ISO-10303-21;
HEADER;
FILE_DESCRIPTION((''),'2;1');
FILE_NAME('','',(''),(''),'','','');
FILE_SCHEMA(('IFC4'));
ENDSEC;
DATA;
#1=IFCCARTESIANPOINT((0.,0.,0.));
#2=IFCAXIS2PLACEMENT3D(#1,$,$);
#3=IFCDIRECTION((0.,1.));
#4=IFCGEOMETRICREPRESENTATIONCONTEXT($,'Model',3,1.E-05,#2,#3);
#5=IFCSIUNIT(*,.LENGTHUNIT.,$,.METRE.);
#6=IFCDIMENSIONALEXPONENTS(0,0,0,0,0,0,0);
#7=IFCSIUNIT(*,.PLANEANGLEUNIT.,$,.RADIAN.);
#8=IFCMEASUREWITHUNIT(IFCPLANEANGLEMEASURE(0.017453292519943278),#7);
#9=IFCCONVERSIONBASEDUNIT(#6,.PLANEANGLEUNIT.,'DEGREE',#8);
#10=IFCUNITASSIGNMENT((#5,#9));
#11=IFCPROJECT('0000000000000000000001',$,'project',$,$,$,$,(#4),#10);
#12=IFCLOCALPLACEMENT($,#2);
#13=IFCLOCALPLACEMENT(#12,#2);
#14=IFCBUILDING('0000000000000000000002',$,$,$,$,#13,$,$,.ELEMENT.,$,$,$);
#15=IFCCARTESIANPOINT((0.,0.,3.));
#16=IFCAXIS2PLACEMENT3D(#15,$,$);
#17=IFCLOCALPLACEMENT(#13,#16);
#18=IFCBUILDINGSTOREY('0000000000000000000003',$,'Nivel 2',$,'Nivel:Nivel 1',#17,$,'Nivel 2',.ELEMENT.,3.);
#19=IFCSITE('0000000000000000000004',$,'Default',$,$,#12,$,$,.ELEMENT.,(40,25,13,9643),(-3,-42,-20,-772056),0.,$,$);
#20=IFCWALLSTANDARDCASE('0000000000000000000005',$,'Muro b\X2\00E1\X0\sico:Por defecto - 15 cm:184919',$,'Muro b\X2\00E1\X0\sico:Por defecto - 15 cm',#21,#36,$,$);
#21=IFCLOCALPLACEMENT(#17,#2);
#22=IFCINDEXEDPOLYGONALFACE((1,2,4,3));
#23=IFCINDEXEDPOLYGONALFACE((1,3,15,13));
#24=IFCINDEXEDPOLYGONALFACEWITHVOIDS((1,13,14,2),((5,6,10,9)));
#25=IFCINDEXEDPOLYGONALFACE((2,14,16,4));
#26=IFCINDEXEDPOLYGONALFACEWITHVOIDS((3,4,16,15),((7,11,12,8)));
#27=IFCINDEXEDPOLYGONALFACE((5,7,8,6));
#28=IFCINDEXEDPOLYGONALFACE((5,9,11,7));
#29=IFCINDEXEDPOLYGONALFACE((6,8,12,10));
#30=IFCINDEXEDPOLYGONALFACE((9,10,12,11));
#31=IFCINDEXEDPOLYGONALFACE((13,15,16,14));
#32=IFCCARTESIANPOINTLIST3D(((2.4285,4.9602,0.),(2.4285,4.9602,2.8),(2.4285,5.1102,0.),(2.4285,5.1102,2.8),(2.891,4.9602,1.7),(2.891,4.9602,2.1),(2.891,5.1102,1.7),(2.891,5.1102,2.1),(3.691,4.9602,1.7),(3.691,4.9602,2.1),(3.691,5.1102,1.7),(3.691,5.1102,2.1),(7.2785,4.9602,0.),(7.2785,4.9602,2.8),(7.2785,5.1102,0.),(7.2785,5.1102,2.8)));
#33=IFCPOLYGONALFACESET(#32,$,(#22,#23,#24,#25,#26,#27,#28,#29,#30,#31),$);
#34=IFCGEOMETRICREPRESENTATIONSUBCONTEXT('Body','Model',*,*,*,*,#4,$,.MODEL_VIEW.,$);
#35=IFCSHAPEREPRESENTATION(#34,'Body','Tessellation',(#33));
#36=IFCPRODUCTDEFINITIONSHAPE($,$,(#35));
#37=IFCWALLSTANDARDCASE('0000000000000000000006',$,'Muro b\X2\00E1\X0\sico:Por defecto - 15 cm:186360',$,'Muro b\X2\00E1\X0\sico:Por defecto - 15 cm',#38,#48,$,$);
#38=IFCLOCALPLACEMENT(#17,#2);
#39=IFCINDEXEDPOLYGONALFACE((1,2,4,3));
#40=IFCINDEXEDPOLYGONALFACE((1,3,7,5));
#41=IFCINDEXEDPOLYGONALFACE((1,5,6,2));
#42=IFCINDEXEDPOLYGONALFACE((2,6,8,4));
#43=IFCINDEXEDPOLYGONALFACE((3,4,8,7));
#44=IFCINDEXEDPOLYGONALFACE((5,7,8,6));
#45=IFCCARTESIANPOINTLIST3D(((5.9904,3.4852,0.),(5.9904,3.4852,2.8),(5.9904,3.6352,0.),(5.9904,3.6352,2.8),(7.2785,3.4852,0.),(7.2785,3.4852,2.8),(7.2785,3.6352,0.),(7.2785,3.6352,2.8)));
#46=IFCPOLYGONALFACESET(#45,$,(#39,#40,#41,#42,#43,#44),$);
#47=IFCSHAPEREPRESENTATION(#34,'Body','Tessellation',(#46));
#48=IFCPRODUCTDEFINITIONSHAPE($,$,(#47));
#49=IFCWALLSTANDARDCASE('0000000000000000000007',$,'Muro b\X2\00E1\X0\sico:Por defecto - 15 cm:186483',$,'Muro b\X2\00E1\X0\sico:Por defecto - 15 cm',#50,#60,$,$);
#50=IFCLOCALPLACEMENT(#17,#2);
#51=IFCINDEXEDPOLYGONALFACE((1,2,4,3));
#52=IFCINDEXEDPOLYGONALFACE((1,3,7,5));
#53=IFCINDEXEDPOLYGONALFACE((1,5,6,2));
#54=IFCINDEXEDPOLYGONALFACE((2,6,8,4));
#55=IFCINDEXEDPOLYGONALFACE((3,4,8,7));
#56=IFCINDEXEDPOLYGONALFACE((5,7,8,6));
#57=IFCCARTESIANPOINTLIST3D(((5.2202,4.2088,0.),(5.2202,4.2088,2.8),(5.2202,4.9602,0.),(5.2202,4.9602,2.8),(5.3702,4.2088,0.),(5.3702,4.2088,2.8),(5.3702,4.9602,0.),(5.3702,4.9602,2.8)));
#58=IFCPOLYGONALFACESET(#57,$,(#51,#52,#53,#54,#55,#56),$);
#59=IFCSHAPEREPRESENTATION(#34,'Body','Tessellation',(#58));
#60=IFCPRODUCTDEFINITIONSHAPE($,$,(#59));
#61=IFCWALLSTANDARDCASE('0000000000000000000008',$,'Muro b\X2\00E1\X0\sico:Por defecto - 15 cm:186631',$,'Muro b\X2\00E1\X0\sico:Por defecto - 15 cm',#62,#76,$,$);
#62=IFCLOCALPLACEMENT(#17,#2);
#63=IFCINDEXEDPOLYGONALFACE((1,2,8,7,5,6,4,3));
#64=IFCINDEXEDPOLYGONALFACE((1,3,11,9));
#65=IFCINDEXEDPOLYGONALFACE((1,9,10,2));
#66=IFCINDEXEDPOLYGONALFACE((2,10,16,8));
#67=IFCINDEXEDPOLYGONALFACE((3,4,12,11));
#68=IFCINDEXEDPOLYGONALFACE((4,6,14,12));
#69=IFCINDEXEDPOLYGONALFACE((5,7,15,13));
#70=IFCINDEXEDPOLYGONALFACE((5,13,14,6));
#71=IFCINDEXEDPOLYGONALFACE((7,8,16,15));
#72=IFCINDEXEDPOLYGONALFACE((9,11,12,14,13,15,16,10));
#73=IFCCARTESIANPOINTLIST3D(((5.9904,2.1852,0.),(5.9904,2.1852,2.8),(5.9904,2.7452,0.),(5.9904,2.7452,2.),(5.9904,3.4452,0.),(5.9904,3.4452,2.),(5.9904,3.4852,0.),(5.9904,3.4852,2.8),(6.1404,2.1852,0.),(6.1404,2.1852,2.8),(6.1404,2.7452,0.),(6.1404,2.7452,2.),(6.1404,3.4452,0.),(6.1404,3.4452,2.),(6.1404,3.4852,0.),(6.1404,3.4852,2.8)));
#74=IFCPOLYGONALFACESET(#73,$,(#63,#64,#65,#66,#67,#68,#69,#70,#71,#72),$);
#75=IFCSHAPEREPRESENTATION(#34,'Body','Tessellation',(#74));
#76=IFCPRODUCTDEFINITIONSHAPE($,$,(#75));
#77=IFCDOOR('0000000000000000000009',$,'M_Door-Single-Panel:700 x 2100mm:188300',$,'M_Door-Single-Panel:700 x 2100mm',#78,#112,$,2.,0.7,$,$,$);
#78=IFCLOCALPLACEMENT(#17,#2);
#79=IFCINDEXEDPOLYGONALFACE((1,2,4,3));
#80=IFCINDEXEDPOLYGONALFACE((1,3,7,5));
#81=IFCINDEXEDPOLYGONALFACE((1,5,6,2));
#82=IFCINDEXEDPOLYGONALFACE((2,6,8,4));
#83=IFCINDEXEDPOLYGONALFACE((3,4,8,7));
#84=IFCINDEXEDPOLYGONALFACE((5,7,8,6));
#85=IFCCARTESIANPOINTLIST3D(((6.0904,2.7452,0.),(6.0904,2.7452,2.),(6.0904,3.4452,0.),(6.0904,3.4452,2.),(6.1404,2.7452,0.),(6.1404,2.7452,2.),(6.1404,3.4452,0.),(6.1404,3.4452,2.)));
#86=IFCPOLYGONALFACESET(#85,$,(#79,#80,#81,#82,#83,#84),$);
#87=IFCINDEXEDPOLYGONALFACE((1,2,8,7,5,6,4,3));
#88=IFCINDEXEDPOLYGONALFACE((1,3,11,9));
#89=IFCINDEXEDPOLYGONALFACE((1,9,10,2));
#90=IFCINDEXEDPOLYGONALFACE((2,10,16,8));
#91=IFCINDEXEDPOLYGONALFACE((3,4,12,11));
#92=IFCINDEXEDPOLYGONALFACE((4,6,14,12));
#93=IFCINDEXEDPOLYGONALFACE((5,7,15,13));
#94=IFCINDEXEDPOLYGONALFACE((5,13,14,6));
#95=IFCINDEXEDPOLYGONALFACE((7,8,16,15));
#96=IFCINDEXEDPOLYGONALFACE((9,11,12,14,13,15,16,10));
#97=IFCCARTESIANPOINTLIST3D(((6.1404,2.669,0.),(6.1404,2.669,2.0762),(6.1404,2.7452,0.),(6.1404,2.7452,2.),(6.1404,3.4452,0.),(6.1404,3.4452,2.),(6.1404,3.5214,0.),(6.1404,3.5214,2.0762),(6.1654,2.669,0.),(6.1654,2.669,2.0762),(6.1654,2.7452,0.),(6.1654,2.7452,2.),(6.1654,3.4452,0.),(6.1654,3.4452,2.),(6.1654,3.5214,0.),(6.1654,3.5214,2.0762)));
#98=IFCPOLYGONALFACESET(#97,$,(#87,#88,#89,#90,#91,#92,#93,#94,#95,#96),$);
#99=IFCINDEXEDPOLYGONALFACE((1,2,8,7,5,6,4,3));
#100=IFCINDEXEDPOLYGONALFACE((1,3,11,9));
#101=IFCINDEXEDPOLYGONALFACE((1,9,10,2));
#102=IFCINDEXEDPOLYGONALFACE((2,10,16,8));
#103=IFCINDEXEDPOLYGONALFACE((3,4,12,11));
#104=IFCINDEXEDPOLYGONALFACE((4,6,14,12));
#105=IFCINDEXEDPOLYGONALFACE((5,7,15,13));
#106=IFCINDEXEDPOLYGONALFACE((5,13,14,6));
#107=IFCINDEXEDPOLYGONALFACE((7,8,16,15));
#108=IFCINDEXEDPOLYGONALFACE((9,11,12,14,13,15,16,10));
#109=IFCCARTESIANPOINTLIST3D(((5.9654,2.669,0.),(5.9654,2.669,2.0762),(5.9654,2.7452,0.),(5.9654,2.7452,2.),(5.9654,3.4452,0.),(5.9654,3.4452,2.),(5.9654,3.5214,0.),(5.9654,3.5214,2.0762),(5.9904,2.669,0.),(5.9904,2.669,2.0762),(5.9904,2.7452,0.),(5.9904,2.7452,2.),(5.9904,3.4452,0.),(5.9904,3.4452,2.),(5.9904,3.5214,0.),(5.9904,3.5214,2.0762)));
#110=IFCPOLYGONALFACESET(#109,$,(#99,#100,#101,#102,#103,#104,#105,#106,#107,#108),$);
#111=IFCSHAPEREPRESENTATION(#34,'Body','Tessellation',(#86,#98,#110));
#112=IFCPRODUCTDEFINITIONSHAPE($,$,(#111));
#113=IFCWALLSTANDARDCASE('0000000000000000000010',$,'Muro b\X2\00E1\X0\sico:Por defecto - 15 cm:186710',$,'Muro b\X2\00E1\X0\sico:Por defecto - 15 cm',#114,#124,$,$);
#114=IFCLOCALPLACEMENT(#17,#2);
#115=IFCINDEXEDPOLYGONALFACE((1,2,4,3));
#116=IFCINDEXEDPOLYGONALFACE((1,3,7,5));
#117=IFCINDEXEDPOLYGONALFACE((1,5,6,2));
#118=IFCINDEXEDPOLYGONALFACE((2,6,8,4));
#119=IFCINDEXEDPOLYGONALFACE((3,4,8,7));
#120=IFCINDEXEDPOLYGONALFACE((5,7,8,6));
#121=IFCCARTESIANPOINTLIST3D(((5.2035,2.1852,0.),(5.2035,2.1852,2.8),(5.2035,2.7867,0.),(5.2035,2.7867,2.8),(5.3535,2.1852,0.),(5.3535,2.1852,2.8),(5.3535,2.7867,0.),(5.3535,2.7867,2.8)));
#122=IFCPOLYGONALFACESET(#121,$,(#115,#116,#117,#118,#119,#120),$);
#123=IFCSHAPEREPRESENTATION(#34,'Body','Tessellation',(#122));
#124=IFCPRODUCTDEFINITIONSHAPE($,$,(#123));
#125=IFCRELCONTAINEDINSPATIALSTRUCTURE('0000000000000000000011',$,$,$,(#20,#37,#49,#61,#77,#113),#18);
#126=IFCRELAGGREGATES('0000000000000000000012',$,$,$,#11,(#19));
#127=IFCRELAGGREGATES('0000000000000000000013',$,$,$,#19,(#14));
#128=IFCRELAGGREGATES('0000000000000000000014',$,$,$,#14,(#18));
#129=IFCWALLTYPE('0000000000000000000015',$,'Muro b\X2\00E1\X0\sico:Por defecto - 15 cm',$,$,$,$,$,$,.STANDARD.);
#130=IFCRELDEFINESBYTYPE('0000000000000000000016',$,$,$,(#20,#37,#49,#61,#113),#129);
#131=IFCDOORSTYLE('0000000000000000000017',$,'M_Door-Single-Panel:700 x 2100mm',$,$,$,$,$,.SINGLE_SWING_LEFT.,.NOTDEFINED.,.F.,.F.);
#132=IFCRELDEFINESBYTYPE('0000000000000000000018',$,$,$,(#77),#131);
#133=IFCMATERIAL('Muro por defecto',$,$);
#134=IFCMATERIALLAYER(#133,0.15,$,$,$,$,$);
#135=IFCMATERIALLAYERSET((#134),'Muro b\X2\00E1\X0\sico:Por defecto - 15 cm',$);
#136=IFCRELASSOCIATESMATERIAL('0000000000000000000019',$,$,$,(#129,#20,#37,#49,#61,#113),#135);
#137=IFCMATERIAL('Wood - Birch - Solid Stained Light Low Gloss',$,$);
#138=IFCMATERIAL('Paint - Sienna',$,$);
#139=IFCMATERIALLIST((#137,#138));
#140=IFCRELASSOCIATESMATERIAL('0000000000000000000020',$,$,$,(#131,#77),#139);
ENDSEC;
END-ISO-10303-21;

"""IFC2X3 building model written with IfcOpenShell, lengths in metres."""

from ifc_helpers import new_model, entity, si_unit, converted_unit, direction, frame, frame_2d, origin, origin_2d_with_axis, place, context, subcontext, project, spatial, polyline, rectangle, outline, extrude, clip, bounded_halfspace, source, transform, mapped, material, material_list, layer, layer_set, layer_usage, type_object, type_shapes, element, fill, save


model = new_model("IFC2X3")

# Units and contexts
model_context = context("Model", 3, precision=1e-05, world=origin(), true_north=direction((0.0, 1.0)))
body_context = subcontext(model_context, "Body", "Model", "MODEL_VIEW")
ifc_project = project(units=[si_unit("LENGTHUNIT", "METRE"), converted_unit("PLANEANGLEUNIT", "DEGREE", entity("IfcPlaneAngleMeasure", 0.017453292519943278), si_unit("PLANEANGLEUNIT", "RADIAN"), dimensions=[0, 0, 0, 0, 0, 0, 0])], contexts=[model_context])

# Site, building, storey
site_placement = place(None, origin())
site = spatial("IfcSite", under=ifc_project, at=site_placement, Name="Default", CompositionType="ELEMENT", RefLatitude=(40, 25, 13, 9643), RefLongitude=(-3, -42, -20, -772056), RefElevation=0.0)
building_placement = place(site_placement, origin())
building = spatial("IfcBuilding", under=site, at=building_placement, CompositionType="ELEMENT")
storey_placement = place(building_placement, frame((0.0, 0.0, 3.0)))
storey = spatial("IfcBuildingStorey", under=building, at=storey_placement, Name="Nivel 2", ObjectType="Nivel:Nivel 1", LongName="Nivel 2", CompositionType="ELEMENT", Elevation=3.0)

# Shared definitions
ifc_material_1 = material(Name="Muro por defecto")
ifc_layer_1 = layer(ifc_material_1, 0.15)
ifc_layer_set_1 = layer_set([ifc_layer_1], Name="Muro básico:Por defecto - 15 cm")
wall_type_1 = type_object("IfcWallType", Name="Muro básico:Por defecto - 15 cm", PredefinedType="STANDARD", material=ifc_layer_set_1)

# Shared definitions
ifc_material_2 = material(Name="Wood - Birch - Solid Stained Light Low Gloss")
ifc_material_3 = material(Name="Paint - Sienna")
ifc_material_list_1 = material_list([ifc_material_2, ifc_material_3])

# Walls, openings
ifc_layer_usage_1 = layer_usage(ifc_layer_set_1, "AXIS2", "NEGATIVE", 0.075)
wall_1_placement = place(storey_placement, frame((2.4285, 5.0352, 0.0)))
wall_1 = element("IfcWallStandardCase", 1, at=wall_1_placement, inside=storey, type_object=wall_type_1, material=ifc_layer_usage_1, Name="Muro básico:Por defecto - 15 cm:184919", ObjectType="Muro básico:Por defecto - 15 cm", context=body_context, shape_type="Clipping", body=[
    clip(extrude(rectangle(XDim=4.85, YDim=0.15, at=frame_2d((2.425, 0.0), x_axis=(-1.0, 0.0))), origin(), (0.0, 0.0, 1.0), 2.8), bounded_halfspace(frame((0.0, -0.075, 2.8), z_axis=(0.0, 0.0, -1.0), x_axis=(1.0, 0.0, 0.0)), True, frame((0.0, -0.075, 2.8)), polyline([(0.0, 0.0), (1.725, 0.0), (1.875, 0.0), (2.7917, 0.0), (2.9417, 0.0), (4.85, 0.0), (4.85, 0.15), (0.0, 0.15), (0.0, 0.0)]))),
])
opening_1_placement = place(wall_1_placement, frame((0.4625, -0.075, 1.7)))
element("IfcOpeningElement", 2, at=opening_1_placement, cuts=wall_1, ObjectType="Opening", context=body_context, shape_type="SweptSolid", body=[
    extrude(rectangle(XDim=0.4, YDim=0.8, at=frame_2d((0.2, 0.4), x_axis=(1.0, 0.0))), frame((0.0, 0.0, 0.0), z_axis=(0.0, 1.0, 0.0), x_axis=(0.0, 0.0, 1.0)), (0.0, 0.0, 1.0), 0.15),
])
ifc_layer_usage_2 = layer_usage(ifc_layer_set_1, "AXIS2", "NEGATIVE", 0.075)
wall_2_placement = place(storey_placement, frame((7.2785, 3.5602, 0.0), z_axis=(0.0, 0.0, 1.0), x_axis=(-1.0, 0.0, 0.0)))
wall_2 = element("IfcWallStandardCase", 3, at=wall_2_placement, inside=storey, type_object=wall_type_1, material=ifc_layer_usage_2, Name="Muro básico:Por defecto - 15 cm:186360", ObjectType="Muro básico:Por defecto - 15 cm", context=body_context, shape_type="Clipping", body=[
    clip(extrude(rectangle(XDim=1.2882, YDim=0.15, at=frame_2d((0.6441, 0.0), x_axis=(-1.0, 0.0))), origin(), (0.0, 0.0, 1.0), 2.8), bounded_halfspace(frame((0.0, -0.075, 2.8), z_axis=(0.0, 0.0, -1.0), x_axis=(-1.0, 0.0, 0.0)), True, frame((0.0, -0.075, 2.8)), polyline([(0.0, 0.0), (1.2882, 0.0), (1.2882, 0.15), (1.1382, 0.15), (0.0, 0.15), (0.0, 0.0)]))),
])
opening_2_placement = place(wall_2_placement, origin())
element("IfcOpeningElement", 4, at=opening_2_placement, cuts=wall_2, ObjectType="Opening", context=body_context, shape_type="SweptSolid", body=[
    extrude(rectangle(XDim=2.0, YDim=0.15, at=frame_2d((0.0, 0.0), x_axis=(0.0, 1.0))), frame((1.2132, 0.115, 1.0), z_axis=(0.0, 1.0, 0.0), x_axis=(1.0, 0.0, 0.0)), (0.0, 0.0, 1.0), 0.7),
])

# Wall
ifc_layer_usage_3 = layer_usage(ifc_layer_set_1, "AXIS2", "POSITIVE", -0.075)
wall_3_placement = place(storey_placement, frame((5.2952, 4.9602, 0.0), z_axis=(0.0, 0.0, 1.0), x_axis=(0.0, -1.0, 0.0)))
element("IfcWallStandardCase", 5, at=wall_3_placement, inside=storey, type_object=wall_type_1, material=ifc_layer_usage_3, Name="Muro básico:Por defecto - 15 cm:186483", ObjectType="Muro básico:Por defecto - 15 cm", context=body_context, shape_type="Clipping", body=[
    clip(extrude(rectangle(XDim=0.7514, YDim=0.15, at=frame_2d((0.3757, 0.0), x_axis=(-1.0, 0.0))), origin(), (0.0, 0.0, 1.0), 2.8), bounded_halfspace(frame((0.0, -0.075, 2.8), z_axis=(0.0, 0.0, -1.0), x_axis=(0.0, 1.0, 0.0)), True, frame((0.0, -0.075, 2.8)), polyline([(0.0, 0.0), (0.7514, 0.0), (0.7514, 0.15), (0.0, 0.15), (0.0, 0.0)]))),
])

# Wall, opening, door
ifc_layer_usage_4 = layer_usage(ifc_layer_set_1, "AXIS2", "NEGATIVE", 0.075)
wall_4_placement = place(storey_placement, frame((6.0654, 2.1852, 0.0), z_axis=(0.0, 0.0, 1.0), x_axis=(0.0, 1.0, 0.0)))
wall_4 = element("IfcWallStandardCase", 6, at=wall_4_placement, inside=storey, type_object=wall_type_1, material=ifc_layer_usage_4, Name="Muro básico:Por defecto - 15 cm:186631", ObjectType="Muro básico:Por defecto - 15 cm", context=body_context, shape_type="Clipping", body=[
    clip(extrude(rectangle(XDim=1.3, YDim=0.15, at=frame_2d((0.65, 0.0), x_axis=(-1.0, 0.0))), origin(), (0.0, 0.0, 1.0), 2.8), bounded_halfspace(frame((0.0, -0.075, 2.8), z_axis=(0.0, 0.0, -1.0), x_axis=(0.0, -1.0, 0.0)), True, frame((0.0, -0.075, 2.8)), polyline([(0.0, 0.0), (1.3, 0.0), (1.3, 0.15), (0.0, 0.15), (0.0, 0.0)]))),
])
opening_3_placement = place(wall_4_placement, frame((1.26, 0.075, 0.0)))
opening_3 = element("IfcOpeningElement", 7, at=opening_3_placement, cuts=wall_4, ObjectType="Opening", context=body_context, shape_type="SweptSolid", body=[
    extrude(rectangle(XDim=0.7, YDim=2.0, at=frame_2d((1.0, 0.35), x_axis=(0.0, -1.0))), frame((0.0, 0.0, 0.0), z_axis=(0.0, -1.0, 0.0), x_axis=(0.0, 0.0, 1.0)), (0.0, 0.0, 1.0), 0.15),
])
door_style_1 = type_object("IfcDoorStyle", Name="M_Door-Single-Panel:700 x 2100mm", ConstructionType="NOTDEFINED", OperationType="SINGLE_SWING_LEFT", ParameterTakesPrecedence=False, Sizeable=False, material=ifc_material_list_1)
shared_shape_1 = source(origin(), body_context, "Body", "SweptSolid", [
    extrude(rectangle(XDim=0.7, YDim=0.05, at=origin_2d_with_axis()), frame((0.35, 0.125, 0.0)), (0.0, 0.0, 1.0), 2.0),
    extrude(outline(polyline([(-0.4262, -1.0571), (0.4262, -1.0571), (0.4262, 1.0191), (0.35, 1.0191), (0.35, -0.981), (-0.35, -0.981), (-0.35, 1.0191), (-0.4262, 1.0191), (-0.4262, -1.0571)])), frame((0.35, 0.175, 1.0191), z_axis=(0.0, -1.0, 0.0), x_axis=(-1.0, 0.0, 0.0)), (0.0, 0.0, 1.0), 0.025),
    extrude(outline(polyline([(-1.0571, -0.4262), (1.019, -0.4262), (1.019, -0.35), (-0.9809, -0.35), (-0.9809, 0.35), (1.019, 0.35), (1.019, 0.4262), (-1.0571, 0.4262), (-1.0571, -0.4262)])), frame((0.35, 0.0, 1.019), z_axis=(0.0, -1.0, 0.0), x_axis=(0.0, 0.0, -1.0)), (0.0, 0.0, 1.0), 0.025),
])
type_shapes(door_style_1, [shared_shape_1])
door_1_placement = place(opening_3_placement, frame((0.0, 0.0, 0.0), z_axis=(0.0, 0.0, 1.0), x_axis=(-1.0, 0.0, 0.0)))
door_1 = element("IfcDoor", 8, at=door_1_placement, inside=storey, type_object=door_style_1, material=ifc_material_list_1, Name="M_Door-Single-Panel:700 x 2100mm:188300", ObjectType="M_Door-Single-Panel:700 x 2100mm", OverallHeight=2.0, OverallWidth=0.7, context=body_context, shape_type="MappedRepresentation", body=[
    mapped(shared_shape_1, transform((0.0, 0.0, 0.0), scale=1.0)),
])
fill(opening_3, door_1)

# Wall
ifc_layer_usage_5 = layer_usage(ifc_layer_set_1, "AXIS2", "NEGATIVE", 0.075)
wall_5_placement = place(storey_placement, frame((5.2785, 2.1852, 0.0), z_axis=(0.0, 0.0, 1.0), x_axis=(0.0, 1.0, 0.0)))
element("IfcWallStandardCase", 9, at=wall_5_placement, inside=storey, type_object=wall_type_1, material=ifc_layer_usage_5, Name="Muro básico:Por defecto - 15 cm:186710", ObjectType="Muro básico:Por defecto - 15 cm", context=body_context, shape_type="Clipping", body=[
    clip(extrude(rectangle(XDim=0.6014, YDim=0.15, at=frame_2d((0.3007, 0.0), x_axis=(-1.0, 0.0))), origin(), (0.0, 0.0, 1.0), 2.8), bounded_halfspace(frame((0.0, -0.075, 2.8), z_axis=(0.0, 0.0, -1.0), x_axis=(0.0, -1.0, 0.0)), True, frame((0.0, -0.075, 2.8)), polyline([(0.0, 0.0), (0.6014, 0.0), (0.6014, 0.15), (0.0, 0.15), (0.0, 0.0)]))),
])

save(model, "model.ifc")
